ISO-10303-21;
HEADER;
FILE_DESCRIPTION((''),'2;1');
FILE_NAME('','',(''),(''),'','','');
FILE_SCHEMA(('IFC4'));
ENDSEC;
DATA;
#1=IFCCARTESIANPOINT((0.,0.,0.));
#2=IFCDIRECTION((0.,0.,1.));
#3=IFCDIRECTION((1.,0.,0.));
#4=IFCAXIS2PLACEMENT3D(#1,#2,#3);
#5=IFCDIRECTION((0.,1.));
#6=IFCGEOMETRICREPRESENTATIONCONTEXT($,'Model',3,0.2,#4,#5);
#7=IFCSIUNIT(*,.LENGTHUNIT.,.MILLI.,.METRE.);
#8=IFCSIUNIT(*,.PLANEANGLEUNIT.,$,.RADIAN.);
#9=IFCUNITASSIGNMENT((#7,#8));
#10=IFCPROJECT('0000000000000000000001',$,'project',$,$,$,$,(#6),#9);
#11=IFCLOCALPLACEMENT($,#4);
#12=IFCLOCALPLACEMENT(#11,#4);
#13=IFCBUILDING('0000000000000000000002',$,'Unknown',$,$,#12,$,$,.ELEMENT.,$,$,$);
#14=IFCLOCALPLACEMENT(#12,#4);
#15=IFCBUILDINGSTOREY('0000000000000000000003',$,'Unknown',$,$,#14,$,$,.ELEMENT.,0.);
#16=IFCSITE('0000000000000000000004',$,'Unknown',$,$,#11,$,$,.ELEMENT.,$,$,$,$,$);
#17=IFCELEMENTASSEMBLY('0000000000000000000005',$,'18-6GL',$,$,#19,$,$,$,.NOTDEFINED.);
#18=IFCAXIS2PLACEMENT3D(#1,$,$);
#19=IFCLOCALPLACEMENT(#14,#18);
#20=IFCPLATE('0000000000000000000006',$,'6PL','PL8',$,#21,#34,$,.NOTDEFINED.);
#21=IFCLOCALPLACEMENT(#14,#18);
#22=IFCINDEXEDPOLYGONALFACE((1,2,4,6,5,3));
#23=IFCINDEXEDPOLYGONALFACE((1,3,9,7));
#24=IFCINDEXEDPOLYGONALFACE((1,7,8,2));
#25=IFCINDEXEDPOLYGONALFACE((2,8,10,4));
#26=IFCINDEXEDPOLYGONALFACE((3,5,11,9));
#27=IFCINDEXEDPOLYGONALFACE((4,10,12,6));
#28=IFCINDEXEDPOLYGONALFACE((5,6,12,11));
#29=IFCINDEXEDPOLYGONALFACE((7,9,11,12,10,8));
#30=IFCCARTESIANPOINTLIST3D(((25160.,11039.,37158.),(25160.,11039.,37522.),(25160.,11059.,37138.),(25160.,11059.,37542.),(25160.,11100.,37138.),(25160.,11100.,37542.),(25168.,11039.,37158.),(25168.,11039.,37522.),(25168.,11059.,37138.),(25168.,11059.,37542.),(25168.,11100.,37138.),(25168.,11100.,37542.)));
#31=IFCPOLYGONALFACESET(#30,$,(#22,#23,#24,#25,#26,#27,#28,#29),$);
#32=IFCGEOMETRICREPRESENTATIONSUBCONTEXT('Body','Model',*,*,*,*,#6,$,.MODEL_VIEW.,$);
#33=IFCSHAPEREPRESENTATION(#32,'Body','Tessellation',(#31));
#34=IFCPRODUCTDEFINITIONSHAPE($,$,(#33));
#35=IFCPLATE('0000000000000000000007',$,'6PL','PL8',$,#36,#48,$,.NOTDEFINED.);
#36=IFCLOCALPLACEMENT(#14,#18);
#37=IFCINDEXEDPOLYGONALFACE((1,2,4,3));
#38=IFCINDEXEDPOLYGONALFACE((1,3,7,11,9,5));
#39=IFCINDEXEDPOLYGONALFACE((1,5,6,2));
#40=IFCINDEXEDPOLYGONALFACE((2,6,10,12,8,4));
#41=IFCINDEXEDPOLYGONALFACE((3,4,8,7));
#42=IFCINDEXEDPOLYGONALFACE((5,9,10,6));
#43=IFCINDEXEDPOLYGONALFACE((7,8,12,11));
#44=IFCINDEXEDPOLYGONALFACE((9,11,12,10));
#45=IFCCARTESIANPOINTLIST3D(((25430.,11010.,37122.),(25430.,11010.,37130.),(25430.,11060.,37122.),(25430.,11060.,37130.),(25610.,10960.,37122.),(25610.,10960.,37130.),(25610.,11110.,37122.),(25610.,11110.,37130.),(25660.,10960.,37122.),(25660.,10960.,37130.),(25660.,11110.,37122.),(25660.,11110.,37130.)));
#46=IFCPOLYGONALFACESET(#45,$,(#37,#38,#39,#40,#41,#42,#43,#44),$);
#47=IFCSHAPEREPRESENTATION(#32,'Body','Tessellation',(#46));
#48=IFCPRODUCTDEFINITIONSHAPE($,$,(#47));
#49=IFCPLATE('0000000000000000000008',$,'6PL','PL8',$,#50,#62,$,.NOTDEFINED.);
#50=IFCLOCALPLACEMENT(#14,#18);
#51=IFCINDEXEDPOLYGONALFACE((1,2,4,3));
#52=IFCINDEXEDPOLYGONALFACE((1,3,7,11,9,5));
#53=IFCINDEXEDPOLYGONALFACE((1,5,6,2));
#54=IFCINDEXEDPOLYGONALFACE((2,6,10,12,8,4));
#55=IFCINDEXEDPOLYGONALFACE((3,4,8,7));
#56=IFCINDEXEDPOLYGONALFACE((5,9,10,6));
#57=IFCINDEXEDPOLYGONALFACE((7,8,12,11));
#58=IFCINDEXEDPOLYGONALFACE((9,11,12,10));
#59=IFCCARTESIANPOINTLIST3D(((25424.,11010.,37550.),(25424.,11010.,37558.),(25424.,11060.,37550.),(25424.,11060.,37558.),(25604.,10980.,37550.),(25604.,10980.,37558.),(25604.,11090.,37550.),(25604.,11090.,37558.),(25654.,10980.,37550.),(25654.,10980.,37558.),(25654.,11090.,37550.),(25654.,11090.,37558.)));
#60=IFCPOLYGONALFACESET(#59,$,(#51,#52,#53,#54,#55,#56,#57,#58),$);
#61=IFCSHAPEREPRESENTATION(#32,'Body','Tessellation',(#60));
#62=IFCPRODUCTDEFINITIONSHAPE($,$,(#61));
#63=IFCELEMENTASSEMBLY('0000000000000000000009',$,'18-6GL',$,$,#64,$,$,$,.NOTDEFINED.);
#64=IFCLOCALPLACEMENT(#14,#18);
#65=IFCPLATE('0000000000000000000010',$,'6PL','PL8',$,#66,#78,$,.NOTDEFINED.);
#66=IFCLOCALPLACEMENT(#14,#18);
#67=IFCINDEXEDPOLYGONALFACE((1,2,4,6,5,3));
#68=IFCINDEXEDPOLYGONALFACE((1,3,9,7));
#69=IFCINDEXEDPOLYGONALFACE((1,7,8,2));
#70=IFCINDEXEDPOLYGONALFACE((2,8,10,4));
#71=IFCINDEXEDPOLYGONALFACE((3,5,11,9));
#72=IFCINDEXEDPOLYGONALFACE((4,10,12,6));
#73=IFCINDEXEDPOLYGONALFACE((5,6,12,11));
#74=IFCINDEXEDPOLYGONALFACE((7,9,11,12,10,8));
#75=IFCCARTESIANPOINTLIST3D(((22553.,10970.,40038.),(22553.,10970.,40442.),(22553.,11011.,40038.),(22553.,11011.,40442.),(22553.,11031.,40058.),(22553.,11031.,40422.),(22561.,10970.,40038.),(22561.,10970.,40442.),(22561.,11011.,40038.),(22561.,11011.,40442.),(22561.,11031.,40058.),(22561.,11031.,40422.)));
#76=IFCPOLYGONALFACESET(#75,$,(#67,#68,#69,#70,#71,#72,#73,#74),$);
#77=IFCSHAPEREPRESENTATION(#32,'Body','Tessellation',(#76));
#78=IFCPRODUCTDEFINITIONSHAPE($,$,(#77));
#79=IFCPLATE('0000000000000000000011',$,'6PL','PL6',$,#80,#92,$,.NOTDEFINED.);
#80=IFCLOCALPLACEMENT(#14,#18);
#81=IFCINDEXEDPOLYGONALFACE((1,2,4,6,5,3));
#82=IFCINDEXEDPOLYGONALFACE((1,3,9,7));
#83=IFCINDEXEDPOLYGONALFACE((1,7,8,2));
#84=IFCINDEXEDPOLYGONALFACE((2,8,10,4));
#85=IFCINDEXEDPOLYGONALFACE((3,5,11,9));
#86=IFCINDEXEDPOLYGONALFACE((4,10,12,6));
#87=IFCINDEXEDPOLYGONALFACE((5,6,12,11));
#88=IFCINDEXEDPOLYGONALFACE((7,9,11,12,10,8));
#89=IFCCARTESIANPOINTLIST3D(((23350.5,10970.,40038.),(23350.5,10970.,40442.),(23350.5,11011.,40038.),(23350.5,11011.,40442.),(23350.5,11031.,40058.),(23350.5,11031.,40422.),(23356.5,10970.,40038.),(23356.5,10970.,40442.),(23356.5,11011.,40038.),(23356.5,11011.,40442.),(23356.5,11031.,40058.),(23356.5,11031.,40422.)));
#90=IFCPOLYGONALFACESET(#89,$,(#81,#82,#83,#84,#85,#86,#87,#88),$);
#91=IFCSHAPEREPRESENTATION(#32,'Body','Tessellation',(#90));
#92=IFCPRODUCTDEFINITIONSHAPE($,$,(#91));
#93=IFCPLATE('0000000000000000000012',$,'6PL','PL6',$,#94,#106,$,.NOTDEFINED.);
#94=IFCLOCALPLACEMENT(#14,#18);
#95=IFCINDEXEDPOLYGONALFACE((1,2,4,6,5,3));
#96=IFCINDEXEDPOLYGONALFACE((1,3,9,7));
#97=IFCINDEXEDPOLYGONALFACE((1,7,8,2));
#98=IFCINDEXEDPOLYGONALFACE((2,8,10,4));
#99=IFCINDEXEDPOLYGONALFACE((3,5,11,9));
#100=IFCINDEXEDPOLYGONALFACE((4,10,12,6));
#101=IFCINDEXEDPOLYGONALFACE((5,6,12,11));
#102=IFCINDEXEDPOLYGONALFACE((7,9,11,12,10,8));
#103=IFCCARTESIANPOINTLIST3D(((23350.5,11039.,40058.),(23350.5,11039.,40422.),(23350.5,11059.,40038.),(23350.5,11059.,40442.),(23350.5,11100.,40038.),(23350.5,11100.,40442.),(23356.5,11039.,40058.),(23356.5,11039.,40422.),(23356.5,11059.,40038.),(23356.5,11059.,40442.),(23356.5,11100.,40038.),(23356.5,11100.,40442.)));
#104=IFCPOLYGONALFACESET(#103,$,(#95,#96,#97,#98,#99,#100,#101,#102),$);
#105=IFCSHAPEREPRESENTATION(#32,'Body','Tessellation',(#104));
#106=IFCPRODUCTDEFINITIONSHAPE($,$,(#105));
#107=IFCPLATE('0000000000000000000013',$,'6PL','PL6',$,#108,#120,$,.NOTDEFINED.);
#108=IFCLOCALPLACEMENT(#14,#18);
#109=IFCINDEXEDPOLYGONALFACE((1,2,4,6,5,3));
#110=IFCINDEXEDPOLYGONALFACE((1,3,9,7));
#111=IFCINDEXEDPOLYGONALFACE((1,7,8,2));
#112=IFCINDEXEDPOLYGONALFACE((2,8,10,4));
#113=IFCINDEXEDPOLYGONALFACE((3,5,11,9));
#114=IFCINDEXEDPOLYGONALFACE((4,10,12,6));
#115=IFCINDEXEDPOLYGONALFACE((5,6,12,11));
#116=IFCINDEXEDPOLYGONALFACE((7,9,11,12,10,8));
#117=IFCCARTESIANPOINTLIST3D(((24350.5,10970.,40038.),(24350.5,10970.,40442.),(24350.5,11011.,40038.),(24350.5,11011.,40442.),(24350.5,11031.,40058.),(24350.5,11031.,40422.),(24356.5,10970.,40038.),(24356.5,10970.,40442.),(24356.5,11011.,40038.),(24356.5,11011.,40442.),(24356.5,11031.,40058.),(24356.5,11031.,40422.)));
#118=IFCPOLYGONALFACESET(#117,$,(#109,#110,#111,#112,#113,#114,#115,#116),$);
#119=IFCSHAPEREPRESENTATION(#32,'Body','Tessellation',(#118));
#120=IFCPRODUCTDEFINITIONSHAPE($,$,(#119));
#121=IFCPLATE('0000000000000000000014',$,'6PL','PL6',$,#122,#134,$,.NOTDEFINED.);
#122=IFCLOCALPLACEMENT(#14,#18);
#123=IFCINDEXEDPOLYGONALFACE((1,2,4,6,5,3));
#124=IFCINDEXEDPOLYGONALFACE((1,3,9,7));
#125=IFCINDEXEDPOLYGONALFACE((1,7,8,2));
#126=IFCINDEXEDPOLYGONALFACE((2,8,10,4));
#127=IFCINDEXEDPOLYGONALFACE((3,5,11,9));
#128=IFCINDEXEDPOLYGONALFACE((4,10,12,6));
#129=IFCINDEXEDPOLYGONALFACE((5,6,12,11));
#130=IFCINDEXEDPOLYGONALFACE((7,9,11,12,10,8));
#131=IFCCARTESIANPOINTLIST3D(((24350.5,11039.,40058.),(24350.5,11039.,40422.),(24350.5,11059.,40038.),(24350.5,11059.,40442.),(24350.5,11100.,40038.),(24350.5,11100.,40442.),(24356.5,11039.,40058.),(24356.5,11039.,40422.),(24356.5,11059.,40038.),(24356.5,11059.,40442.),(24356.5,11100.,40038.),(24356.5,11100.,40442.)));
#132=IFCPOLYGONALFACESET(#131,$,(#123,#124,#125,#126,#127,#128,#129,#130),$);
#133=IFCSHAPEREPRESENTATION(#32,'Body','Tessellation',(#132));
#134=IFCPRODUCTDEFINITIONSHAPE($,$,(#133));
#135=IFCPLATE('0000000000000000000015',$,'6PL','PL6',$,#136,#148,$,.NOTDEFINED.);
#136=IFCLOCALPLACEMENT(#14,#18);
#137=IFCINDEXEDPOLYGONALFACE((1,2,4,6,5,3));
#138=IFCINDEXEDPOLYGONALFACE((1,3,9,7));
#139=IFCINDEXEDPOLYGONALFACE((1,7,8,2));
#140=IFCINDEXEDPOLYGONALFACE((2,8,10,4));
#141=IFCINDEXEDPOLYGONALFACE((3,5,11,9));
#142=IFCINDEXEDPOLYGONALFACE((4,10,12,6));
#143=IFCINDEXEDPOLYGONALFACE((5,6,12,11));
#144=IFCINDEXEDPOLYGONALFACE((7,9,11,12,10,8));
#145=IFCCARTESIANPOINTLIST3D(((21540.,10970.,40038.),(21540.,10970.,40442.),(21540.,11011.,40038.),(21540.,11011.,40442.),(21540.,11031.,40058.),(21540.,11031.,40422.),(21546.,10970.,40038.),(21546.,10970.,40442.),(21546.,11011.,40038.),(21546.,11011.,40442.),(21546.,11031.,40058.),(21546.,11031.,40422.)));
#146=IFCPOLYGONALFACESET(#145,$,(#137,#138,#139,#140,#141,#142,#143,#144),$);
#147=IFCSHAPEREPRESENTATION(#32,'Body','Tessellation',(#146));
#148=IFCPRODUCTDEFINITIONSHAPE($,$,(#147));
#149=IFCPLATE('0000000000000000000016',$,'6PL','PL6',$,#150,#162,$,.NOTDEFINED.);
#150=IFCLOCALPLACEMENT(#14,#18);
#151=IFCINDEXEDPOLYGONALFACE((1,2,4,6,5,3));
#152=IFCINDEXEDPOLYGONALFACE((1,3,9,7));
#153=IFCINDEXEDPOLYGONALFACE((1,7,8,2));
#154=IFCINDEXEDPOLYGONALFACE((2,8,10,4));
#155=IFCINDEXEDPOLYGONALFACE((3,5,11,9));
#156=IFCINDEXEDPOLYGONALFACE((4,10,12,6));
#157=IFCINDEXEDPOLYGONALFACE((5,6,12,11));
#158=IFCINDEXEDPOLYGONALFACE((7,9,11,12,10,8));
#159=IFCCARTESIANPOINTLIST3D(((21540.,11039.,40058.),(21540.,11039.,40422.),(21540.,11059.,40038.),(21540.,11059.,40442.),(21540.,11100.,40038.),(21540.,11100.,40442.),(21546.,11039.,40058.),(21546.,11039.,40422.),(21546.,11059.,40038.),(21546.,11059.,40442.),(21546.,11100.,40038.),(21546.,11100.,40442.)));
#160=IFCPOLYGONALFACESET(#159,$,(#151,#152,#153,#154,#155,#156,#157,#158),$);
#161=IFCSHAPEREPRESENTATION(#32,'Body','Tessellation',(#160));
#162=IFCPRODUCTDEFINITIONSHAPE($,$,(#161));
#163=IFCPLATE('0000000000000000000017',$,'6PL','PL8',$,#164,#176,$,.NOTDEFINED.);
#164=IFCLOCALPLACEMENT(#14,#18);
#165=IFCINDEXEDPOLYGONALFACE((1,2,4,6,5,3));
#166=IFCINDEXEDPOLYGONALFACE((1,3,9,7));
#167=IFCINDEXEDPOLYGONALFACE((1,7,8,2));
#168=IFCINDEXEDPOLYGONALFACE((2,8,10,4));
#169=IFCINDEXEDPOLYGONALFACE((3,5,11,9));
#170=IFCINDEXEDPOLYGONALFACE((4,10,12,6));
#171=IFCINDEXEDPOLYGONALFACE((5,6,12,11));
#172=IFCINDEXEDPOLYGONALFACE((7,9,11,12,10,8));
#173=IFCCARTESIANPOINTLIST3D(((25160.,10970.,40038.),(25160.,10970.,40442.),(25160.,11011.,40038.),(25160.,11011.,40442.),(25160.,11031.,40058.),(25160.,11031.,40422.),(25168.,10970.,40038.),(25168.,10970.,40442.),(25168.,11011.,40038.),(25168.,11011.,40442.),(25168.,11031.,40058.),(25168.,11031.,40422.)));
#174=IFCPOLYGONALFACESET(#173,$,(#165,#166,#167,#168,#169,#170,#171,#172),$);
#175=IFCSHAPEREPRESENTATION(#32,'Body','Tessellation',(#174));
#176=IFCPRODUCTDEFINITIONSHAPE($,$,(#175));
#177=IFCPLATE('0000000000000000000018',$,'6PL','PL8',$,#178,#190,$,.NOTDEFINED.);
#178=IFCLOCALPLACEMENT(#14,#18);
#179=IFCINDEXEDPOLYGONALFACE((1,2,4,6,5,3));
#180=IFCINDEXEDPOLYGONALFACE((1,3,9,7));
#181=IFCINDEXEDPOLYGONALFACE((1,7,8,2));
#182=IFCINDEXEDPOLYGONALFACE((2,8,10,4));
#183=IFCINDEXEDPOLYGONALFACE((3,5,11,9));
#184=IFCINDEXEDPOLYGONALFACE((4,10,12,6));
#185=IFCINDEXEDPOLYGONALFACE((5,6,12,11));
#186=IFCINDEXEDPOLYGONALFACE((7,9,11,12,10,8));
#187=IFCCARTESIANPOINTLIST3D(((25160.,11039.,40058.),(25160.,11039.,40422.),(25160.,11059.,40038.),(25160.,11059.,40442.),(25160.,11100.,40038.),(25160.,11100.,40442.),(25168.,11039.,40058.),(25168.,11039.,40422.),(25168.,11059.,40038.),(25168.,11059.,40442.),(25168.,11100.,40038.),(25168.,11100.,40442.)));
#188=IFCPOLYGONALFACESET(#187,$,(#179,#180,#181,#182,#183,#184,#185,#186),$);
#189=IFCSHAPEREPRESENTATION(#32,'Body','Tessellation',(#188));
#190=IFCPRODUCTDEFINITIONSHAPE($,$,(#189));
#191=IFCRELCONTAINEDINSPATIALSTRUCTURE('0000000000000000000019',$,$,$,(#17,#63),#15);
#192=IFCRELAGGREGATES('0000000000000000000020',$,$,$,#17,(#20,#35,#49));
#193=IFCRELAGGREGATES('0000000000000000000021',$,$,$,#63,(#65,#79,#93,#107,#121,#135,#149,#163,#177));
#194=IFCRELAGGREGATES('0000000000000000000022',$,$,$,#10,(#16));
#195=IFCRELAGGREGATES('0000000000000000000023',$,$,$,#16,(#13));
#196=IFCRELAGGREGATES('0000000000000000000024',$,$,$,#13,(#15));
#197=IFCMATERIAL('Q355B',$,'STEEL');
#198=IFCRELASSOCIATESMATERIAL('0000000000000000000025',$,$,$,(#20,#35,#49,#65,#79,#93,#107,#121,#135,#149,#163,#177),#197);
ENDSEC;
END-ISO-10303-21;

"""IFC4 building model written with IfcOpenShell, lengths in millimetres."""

from ifc_helpers import new_model, si_unit, direction, frame, origin_with_axes, place, context, subcontext, project, spatial, line, indexed_curve, outline, extrude, material, element, aggregate, save


model = new_model("IFC4")

# Units and contexts
model_context = context("Model", 3, precision=0.2, world=origin_with_axes(), true_north=direction((0.0, 1.0)))
body_context = subcontext(model_context, "Body", "Model", "MODEL_VIEW")
ifc_project = project(units=[si_unit("LENGTHUNIT", "METRE", prefix="MILLI"), si_unit("PLANEANGLEUNIT", "RADIAN")], contexts=[model_context])

# Site, building, storey
site_placement = place(None, origin_with_axes())
site = spatial("IfcSite", under=ifc_project, at=site_placement, Name="Unknown", CompositionType="ELEMENT")
building_placement = place(site_placement, origin_with_axes())
building = spatial("IfcBuilding", under=site, at=building_placement, Name="Unknown", CompositionType="ELEMENT")
storey_placement = place(building_placement, origin_with_axes())
storey = spatial("IfcBuildingStorey", under=building, at=storey_placement, Name="Unknown", CompositionType="ELEMENT", Elevation=0.0)

# Element assembly
assembly_1_placement = place(storey_placement, frame((21150.0, 11035.0, 37340.0), z_axis=(0.0, -1.0, 0.0), x_axis=(1.0, 0.0, 0.0)))
assembly_1 = element("IfcElementAssembly", 1, at=assembly_1_placement, inside=storey, Name="18-6GL", PredefinedType="NOTDEFINED")
ifc_material_1 = material(Name="Q355B", Category="STEEL")

# Plates
plate_1_placement = place(assembly_1_placement, frame((4014.0, -202.0, -4.0), z_axis=(1.0, 0.0, 0.0), x_axis=(0.0, 0.0, -1.0)))
plate_1 = element("IfcPlate", 2, at=plate_1_placement, material=ifc_material_1, Name="6PL", Description="PL8", PredefinedType="NOTDEFINED", context=body_context, shape_type="SolidModel", body=[
    extrude(outline(indexed_curve([(0.0, 20.0), (20.0, 0.0), (61.0, 0.0), (61.0, 404.0), (20.0, 404.0), (0.0, 384.0)], segments=[line(1, 2, 3, 4, 5, 6, 1)])), frame((0.0, 0.0, 4.0), z_axis=(0.0, 0.0, 1.0), x_axis=(1.0, 0.0, 0.0)), (0.0, 0.0, -1.0), 8.0),
])
plate_2_placement = place(assembly_1_placement, frame((4460.0, -214.0, 75.0), z_axis=(0.0, 1.0, 0.0), x_axis=(1.0, 0.0, 0.0)))
plate_2 = element("IfcPlate", 3, at=plate_2_placement, material=ifc_material_1, Name="6PL", Description="PL8", PredefinedType="NOTDEFINED", context=body_context, shape_type="SolidModel", body=[
    extrude(outline(indexed_curve([(0.0, 0.0), (50.0, 0.0), (50.0, 150.0), (0.0, 150.0), (-180.0, 100.0), (-180.0, 50.0)], segments=[line(1, 2, 3, 4, 5, 6, 1)])), frame((0.0, 0.0, 4.0), z_axis=(0.0, 0.0, 1.0), x_axis=(1.0, 0.0, 0.0)), (0.0, 0.0, -1.0), 8.0),
])
plate_3_placement = place(assembly_1_placement, frame((4454.0, 214.0, 55.0), z_axis=(0.0, 1.0, 0.0), x_axis=(1.0, 0.0, 0.0)))
plate_3 = element("IfcPlate", 4, at=plate_3_placement, material=ifc_material_1, Name="6PL", Description="PL8", PredefinedType="NOTDEFINED", context=body_context, shape_type="SolidModel", body=[
    extrude(outline(indexed_curve([(0.0, 0.0), (50.0, 0.0), (50.0, 110.0), (0.0, 110.0), (-180.0, 80.0), (-180.0, 30.0)], segments=[line(1, 2, 3, 4, 5, 6, 1)])), frame((0.0, 0.0, 4.0), z_axis=(0.0, 0.0, 1.0), x_axis=(1.0, 0.0, 0.0)), (0.0, 0.0, -1.0), 8.0),
])
aggregate(assembly_1, [plate_1, plate_2, plate_3])

# Element assembly, plates
assembly_2_placement = place(storey_placement, frame((21150.0, 11035.0, 40240.0), z_axis=(0.0, -1.0, 0.0), x_axis=(1.0, 0.0, 0.0)))
assembly_2 = element("IfcElementAssembly", 5, at=assembly_2_placement, inside=storey, Name="18-6GL", PredefinedType="NOTDEFINED")
plate_4_placement = place(assembly_2_placement, frame((1407.0, -202.0, 4.0), z_axis=(-1.0, 0.0, 0.0), x_axis=(0.0, 0.0, 1.0)))
plate_4 = element("IfcPlate", 6, at=plate_4_placement, material=ifc_material_1, Name="6PL", Description="PL8", PredefinedType="NOTDEFINED", context=body_context, shape_type="SolidModel", body=[
    extrude(outline(indexed_curve([(0.0, 20.0), (20.0, 0.0), (61.0, 0.0), (61.0, 404.0), (20.0, 404.0), (0.0, 384.0)], segments=[line(1, 2, 3, 4, 5, 6, 1)])), frame((0.0, 0.0, 4.0), z_axis=(0.0, 0.0, 1.0), x_axis=(1.0, 0.0, 0.0)), (0.0, 0.0, -1.0), 8.0),
])
plate_5_placement = place(assembly_2_placement, frame((2203.5, -202.0, 65.0), z_axis=(1.0, 0.0, 0.0), x_axis=(0.0, 0.0, -1.0)))
plate_5 = element("IfcPlate", 7, at=plate_5_placement, material=ifc_material_1, Name="6PL", Description="PL6", PredefinedType="NOTDEFINED", context=body_context, shape_type="SolidModel", body=[
    extrude(outline(indexed_curve([(0.0, 0.0), (41.0, 0.0), (61.0, 20.0), (61.0, 384.0), (41.0, 404.0), (0.0, 404.0)], segments=[line(1, 2, 3, 4, 5, 6, 1)])), frame((0.0, 0.0, 3.0), z_axis=(0.0, 0.0, 1.0), x_axis=(1.0, 0.0, 0.0)), (0.0, 0.0, -1.0), 6.0),
])
plate_6_placement = place(assembly_2_placement, frame((2203.5, -202.0, -4.0), z_axis=(1.0, 0.0, 0.0), x_axis=(0.0, 0.0, -1.0)))
plate_6 = element("IfcPlate", 8, at=plate_6_placement, material=ifc_material_1, Name="6PL", Description="PL6", PredefinedType="NOTDEFINED", context=body_context, shape_type="SolidModel", body=[
    extrude(outline(indexed_curve([(0.0, 20.0), (20.0, 0.0), (61.0, 0.0), (61.0, 404.0), (20.0, 404.0), (0.0, 384.0)], segments=[line(1, 2, 3, 4, 5, 6, 1)])), frame((0.0, 0.0, 3.0), z_axis=(0.0, 0.0, 1.0), x_axis=(1.0, 0.0, 0.0)), (0.0, 0.0, -1.0), 6.0),
])
plate_7_placement = place(assembly_2_placement, frame((3203.5, -202.0, 65.0), z_axis=(1.0, 0.0, 0.0), x_axis=(0.0, 0.0, -1.0)))
plate_7 = element("IfcPlate", 9, at=plate_7_placement, material=ifc_material_1, Name="6PL", Description="PL6", PredefinedType="NOTDEFINED", context=body_context, shape_type="SolidModel", body=[
    extrude(outline(indexed_curve([(0.0, 0.0), (41.0, 0.0), (61.0, 20.0), (61.0, 384.0), (41.0, 404.0), (0.0, 404.0)], segments=[line(1, 2, 3, 4, 5, 6, 1)])), frame((0.0, 0.0, 3.0), z_axis=(0.0, 0.0, 1.0), x_axis=(1.0, 0.0, 0.0)), (0.0, 0.0, -1.0), 6.0),
])
plate_8_placement = place(assembly_2_placement, frame((3203.5, -202.0, -4.0), z_axis=(1.0, 0.0, 0.0), x_axis=(0.0, 0.0, -1.0)))
plate_8 = element("IfcPlate", 10, at=plate_8_placement, material=ifc_material_1, Name="6PL", Description="PL6", PredefinedType="NOTDEFINED", context=body_context, shape_type="SolidModel", body=[
    extrude(outline(indexed_curve([(0.0, 20.0), (20.0, 0.0), (61.0, 0.0), (61.0, 404.0), (20.0, 404.0), (0.0, 384.0)], segments=[line(1, 2, 3, 4, 5, 6, 1)])), frame((0.0, 0.0, 3.0), z_axis=(0.0, 0.0, 1.0), x_axis=(1.0, 0.0, 0.0)), (0.0, 0.0, -1.0), 6.0),
])
plate_9_placement = place(assembly_2_placement, frame((393.0, -202.0, 65.0), z_axis=(1.0, 0.0, 0.0), x_axis=(0.0, 0.0, -1.0)))
plate_9 = element("IfcPlate", 11, at=plate_9_placement, material=ifc_material_1, Name="6PL", Description="PL6", PredefinedType="NOTDEFINED", context=body_context, shape_type="SolidModel", body=[
    extrude(outline(indexed_curve([(0.0, 0.0), (41.0, 0.0), (61.0, 20.0), (61.0, 384.0), (41.0, 404.0), (0.0, 404.0)], segments=[line(1, 2, 3, 4, 5, 6, 1)])), frame((0.0, 0.0, 3.0), z_axis=(0.0, 0.0, 1.0), x_axis=(1.0, 0.0, 0.0)), (0.0, 0.0, -1.0), 6.0),
])
plate_10_placement = place(assembly_2_placement, frame((393.0, -202.0, -4.0), z_axis=(1.0, 0.0, 0.0), x_axis=(0.0, 0.0, -1.0)))
plate_10 = element("IfcPlate", 12, at=plate_10_placement, material=ifc_material_1, Name="6PL", Description="PL6", PredefinedType="NOTDEFINED", context=body_context, shape_type="SolidModel", body=[
    extrude(outline(indexed_curve([(0.0, 20.0), (20.0, 0.0), (61.0, 0.0), (61.0, 404.0), (20.0, 404.0), (0.0, 384.0)], segments=[line(1, 2, 3, 4, 5, 6, 1)])), frame((0.0, 0.0, 3.0), z_axis=(0.0, 0.0, 1.0), x_axis=(1.0, 0.0, 0.0)), (0.0, 0.0, -1.0), 6.0),
])
plate_11_placement = place(assembly_2_placement, frame((4014.0, -202.0, 65.0), z_axis=(1.0, 0.0, 0.0), x_axis=(0.0, 0.0, -1.0)))
plate_11 = element("IfcPlate", 13, at=plate_11_placement, material=ifc_material_1, Name="6PL", Description="PL8", PredefinedType="NOTDEFINED", context=body_context, shape_type="SolidModel", body=[
    extrude(outline(indexed_curve([(0.0, 0.0), (41.0, 0.0), (61.0, 20.0), (61.0, 384.0), (41.0, 404.0), (0.0, 404.0)], segments=[line(1, 2, 3, 4, 5, 6, 1)])), frame((0.0, 0.0, 4.0), z_axis=(0.0, 0.0, 1.0), x_axis=(1.0, 0.0, 0.0)), (0.0, 0.0, -1.0), 8.0),
])
plate_12_placement = place(assembly_2_placement, frame((4014.0, -202.0, -4.0), z_axis=(1.0, 0.0, 0.0), x_axis=(0.0, 0.0, -1.0)))
plate_12 = element("IfcPlate", 14, at=plate_12_placement, material=ifc_material_1, Name="6PL", Description="PL8", PredefinedType="NOTDEFINED", context=body_context, shape_type="SolidModel", body=[
    extrude(outline(indexed_curve([(0.0, 20.0), (20.0, 0.0), (61.0, 0.0), (61.0, 404.0), (20.0, 404.0), (0.0, 384.0)], segments=[line(1, 2, 3, 4, 5, 6, 1)])), frame((0.0, 0.0, 4.0), z_axis=(0.0, 0.0, 1.0), x_axis=(1.0, 0.0, 0.0)), (0.0, 0.0, -1.0), 8.0),
])
aggregate(assembly_2, [plate_4, plate_5, plate_6, plate_7, plate_8, plate_9, plate_10, plate_11, plate_12])

save(model, "model.ifc")
